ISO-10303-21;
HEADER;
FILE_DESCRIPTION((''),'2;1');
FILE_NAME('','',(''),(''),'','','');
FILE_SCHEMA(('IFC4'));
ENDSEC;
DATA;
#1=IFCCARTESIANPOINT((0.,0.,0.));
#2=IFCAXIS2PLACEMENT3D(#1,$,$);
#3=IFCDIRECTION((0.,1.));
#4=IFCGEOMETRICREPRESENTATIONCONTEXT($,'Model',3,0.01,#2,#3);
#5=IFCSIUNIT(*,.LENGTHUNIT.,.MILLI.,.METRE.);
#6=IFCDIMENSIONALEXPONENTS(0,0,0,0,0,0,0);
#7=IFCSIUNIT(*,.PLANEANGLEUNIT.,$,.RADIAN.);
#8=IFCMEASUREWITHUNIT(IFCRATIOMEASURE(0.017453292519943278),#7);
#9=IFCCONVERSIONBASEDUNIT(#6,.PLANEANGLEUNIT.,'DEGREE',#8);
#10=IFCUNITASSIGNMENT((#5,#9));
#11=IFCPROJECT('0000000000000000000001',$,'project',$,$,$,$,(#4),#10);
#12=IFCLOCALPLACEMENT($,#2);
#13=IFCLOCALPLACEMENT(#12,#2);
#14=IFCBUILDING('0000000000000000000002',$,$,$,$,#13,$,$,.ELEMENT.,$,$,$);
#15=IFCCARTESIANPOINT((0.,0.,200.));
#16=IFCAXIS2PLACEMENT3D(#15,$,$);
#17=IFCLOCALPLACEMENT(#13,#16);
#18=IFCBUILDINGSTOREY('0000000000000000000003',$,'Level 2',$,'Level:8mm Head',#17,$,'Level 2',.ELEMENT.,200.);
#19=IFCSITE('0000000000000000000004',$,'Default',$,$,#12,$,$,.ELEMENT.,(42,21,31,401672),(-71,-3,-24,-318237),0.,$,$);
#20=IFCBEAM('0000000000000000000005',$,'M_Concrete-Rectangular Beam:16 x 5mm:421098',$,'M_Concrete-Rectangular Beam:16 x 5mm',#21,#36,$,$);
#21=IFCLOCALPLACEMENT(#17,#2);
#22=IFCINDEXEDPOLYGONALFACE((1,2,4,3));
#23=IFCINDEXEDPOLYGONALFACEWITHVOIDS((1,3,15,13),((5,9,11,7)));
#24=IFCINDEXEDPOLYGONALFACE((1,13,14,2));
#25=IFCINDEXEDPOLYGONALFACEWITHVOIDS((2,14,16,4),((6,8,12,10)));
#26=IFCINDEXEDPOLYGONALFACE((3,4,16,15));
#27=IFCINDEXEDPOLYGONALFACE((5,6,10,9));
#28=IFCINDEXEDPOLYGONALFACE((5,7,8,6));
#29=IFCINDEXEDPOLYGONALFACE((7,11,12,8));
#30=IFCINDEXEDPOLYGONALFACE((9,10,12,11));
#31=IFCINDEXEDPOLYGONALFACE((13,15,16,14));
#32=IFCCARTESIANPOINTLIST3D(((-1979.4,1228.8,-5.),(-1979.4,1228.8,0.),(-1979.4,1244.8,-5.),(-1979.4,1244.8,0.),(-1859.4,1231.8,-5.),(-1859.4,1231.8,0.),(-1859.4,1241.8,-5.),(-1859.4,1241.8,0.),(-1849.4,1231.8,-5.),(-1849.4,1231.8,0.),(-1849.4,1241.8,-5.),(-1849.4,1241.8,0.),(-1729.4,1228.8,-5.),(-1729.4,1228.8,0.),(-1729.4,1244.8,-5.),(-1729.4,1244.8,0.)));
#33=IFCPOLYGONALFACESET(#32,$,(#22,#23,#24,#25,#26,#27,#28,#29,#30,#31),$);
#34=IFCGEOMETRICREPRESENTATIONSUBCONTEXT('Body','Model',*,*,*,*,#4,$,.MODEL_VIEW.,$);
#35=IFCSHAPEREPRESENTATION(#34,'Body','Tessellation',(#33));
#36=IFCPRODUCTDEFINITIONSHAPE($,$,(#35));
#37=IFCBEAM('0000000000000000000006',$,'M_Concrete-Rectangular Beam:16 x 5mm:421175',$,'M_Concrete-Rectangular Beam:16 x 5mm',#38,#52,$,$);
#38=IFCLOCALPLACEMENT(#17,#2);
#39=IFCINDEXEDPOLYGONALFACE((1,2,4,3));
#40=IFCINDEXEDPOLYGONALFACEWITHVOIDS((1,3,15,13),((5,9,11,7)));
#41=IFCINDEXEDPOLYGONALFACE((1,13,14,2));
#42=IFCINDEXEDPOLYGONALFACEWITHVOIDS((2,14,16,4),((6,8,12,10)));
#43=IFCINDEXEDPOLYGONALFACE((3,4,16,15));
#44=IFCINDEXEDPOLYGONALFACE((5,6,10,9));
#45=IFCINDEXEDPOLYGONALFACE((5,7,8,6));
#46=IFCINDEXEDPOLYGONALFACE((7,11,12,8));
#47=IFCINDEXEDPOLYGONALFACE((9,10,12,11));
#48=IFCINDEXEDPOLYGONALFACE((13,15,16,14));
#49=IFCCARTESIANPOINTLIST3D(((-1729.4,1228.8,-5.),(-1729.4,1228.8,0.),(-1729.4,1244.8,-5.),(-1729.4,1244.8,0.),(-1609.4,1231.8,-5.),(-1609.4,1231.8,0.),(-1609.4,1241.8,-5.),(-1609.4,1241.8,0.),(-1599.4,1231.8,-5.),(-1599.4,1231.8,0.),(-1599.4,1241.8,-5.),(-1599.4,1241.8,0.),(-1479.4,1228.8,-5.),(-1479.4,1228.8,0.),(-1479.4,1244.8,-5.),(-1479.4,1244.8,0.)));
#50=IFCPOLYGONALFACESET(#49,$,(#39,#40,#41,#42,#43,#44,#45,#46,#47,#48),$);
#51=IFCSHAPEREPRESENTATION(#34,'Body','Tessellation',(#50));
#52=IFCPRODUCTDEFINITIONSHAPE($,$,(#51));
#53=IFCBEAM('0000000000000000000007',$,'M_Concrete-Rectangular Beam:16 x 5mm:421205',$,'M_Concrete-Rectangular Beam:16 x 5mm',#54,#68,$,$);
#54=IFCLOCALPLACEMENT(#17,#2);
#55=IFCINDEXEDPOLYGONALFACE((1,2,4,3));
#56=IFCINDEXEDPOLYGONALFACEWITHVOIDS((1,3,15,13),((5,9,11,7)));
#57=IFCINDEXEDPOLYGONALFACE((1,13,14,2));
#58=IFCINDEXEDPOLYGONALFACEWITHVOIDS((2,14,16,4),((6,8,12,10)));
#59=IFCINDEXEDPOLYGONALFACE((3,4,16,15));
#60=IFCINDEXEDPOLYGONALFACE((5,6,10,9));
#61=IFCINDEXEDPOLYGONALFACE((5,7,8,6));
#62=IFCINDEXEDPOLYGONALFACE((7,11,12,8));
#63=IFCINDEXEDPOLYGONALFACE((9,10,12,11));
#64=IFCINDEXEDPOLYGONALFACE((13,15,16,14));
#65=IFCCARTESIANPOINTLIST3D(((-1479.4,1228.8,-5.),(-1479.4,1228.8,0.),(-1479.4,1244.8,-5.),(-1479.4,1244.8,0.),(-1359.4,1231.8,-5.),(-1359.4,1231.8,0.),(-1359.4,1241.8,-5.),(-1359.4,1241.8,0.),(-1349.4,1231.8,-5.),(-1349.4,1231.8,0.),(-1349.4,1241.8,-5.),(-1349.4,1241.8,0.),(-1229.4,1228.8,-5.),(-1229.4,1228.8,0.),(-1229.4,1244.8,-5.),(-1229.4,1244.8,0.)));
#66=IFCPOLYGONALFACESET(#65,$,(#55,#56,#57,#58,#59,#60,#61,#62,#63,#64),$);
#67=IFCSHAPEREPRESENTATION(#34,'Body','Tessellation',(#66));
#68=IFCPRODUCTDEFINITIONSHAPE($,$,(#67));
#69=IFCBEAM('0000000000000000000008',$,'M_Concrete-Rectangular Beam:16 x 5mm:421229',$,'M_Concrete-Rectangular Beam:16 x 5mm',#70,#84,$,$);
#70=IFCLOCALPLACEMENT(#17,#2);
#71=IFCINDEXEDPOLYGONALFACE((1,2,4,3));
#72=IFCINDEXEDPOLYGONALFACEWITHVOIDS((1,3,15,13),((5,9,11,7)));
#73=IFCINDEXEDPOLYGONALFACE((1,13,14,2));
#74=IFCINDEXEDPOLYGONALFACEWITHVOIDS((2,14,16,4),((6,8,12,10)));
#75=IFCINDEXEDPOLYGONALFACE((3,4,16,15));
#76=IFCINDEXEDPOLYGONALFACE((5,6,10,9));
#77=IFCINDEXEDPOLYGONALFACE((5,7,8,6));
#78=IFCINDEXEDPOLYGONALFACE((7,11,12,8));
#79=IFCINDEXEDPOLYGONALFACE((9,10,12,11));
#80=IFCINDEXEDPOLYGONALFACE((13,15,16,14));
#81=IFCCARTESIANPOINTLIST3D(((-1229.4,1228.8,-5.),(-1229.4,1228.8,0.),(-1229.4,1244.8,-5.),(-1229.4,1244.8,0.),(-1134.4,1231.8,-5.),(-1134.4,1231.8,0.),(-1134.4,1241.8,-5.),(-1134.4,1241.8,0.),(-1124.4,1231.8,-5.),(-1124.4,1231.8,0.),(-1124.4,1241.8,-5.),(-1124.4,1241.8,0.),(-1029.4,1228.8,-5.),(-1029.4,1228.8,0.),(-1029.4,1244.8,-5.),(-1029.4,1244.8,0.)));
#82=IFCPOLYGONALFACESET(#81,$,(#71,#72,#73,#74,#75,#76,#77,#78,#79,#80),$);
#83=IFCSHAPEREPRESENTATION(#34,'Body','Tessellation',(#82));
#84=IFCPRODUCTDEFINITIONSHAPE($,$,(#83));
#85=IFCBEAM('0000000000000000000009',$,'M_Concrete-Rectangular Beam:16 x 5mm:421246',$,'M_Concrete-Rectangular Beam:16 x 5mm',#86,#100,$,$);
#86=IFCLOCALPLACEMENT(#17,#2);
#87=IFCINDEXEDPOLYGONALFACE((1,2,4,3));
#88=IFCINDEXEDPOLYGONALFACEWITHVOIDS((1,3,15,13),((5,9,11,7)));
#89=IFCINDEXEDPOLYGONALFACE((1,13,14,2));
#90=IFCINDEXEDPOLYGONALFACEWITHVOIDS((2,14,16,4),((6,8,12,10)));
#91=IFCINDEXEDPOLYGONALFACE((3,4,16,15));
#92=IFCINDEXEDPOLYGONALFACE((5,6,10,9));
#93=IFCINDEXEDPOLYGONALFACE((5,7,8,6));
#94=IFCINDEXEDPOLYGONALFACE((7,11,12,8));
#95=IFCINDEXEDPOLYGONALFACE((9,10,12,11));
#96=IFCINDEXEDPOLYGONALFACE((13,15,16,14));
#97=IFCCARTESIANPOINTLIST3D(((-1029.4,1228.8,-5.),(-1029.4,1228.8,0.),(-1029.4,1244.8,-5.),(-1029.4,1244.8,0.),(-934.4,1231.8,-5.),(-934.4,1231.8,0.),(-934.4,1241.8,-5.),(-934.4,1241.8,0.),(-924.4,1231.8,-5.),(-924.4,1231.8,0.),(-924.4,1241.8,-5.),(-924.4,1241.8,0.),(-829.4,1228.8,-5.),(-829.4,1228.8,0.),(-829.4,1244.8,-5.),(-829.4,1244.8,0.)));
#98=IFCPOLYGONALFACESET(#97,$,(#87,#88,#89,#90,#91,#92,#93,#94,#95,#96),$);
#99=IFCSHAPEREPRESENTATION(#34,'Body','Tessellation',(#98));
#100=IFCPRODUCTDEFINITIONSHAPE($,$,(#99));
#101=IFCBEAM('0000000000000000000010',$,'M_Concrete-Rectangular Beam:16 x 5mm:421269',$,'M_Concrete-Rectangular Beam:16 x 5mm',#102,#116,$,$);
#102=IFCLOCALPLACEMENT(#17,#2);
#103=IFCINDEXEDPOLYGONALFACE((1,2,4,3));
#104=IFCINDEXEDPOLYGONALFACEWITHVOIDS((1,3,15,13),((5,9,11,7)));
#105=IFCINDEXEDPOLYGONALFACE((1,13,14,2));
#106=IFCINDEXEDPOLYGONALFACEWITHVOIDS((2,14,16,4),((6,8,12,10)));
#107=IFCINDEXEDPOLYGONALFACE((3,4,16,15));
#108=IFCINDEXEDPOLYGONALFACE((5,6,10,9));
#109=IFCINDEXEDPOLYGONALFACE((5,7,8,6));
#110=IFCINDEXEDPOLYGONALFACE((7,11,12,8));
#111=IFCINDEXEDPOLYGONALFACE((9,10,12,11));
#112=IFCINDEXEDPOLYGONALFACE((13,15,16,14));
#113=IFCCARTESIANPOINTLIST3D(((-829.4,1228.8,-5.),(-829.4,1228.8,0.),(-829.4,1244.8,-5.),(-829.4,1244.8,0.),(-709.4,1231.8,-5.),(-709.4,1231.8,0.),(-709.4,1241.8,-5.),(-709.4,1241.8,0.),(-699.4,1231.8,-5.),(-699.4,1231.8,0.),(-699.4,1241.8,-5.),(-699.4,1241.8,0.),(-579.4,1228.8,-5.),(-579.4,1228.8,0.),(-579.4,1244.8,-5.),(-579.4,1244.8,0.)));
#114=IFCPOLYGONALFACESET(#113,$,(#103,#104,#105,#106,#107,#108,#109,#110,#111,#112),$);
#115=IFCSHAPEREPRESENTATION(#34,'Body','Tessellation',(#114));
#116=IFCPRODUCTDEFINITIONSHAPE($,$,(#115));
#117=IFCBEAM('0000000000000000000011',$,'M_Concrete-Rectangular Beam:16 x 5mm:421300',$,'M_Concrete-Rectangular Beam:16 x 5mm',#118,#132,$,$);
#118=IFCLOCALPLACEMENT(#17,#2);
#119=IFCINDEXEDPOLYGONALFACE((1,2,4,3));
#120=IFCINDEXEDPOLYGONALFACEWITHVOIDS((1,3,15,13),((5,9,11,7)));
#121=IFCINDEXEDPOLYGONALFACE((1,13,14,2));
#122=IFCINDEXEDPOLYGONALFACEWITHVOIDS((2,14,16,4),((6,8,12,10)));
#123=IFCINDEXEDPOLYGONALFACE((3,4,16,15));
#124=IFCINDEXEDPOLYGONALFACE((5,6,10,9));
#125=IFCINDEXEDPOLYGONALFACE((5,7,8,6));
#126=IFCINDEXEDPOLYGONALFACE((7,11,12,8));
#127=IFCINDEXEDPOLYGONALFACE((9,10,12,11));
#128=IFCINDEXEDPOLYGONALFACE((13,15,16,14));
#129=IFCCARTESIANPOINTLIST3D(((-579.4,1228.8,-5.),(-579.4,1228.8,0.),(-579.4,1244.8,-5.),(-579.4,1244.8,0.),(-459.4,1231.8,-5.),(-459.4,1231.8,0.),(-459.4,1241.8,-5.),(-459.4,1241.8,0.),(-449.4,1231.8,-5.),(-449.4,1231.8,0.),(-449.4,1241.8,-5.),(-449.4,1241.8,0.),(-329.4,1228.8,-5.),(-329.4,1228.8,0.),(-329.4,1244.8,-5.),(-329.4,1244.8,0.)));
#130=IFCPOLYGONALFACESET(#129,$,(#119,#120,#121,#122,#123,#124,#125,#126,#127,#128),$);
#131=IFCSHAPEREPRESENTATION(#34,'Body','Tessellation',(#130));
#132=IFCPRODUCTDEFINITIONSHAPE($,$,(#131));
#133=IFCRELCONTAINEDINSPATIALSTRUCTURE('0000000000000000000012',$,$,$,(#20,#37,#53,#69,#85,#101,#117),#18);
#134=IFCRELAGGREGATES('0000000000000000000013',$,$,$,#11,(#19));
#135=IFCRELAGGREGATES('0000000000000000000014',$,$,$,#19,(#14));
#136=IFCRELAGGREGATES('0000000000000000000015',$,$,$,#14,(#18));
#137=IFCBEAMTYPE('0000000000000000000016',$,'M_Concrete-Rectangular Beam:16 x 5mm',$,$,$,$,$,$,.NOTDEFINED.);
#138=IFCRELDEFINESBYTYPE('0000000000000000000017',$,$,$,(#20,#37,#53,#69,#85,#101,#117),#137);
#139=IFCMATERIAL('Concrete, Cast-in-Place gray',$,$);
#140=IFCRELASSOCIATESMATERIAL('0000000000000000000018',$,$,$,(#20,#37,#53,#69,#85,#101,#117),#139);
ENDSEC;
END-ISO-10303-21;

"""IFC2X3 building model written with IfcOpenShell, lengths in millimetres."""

from ifc_helpers import new_model, entity, si_unit, converted_unit, direction, frame, frame_2d, origin, place, context, subcontext, project, spatial, rectangle, extrude, boolean, material, type_object, element, save


model = new_model("IFC2X3")

# Units and contexts
model_context = context("Model", 3, precision=0.01, world=origin(), true_north=direction((0.0, 1.0)))
body_context = subcontext(model_context, "Body", "Model", "MODEL_VIEW")
ifc_project = project(units=[si_unit("LENGTHUNIT", "METRE", prefix="MILLI"), converted_unit("PLANEANGLEUNIT", "DEGREE", entity("IfcRatioMeasure", 0.017453292519943278), si_unit("PLANEANGLEUNIT", "RADIAN"), dimensions=[0, 0, 0, 0, 0, 0, 0])], contexts=[model_context])

# Site, building, storey
site_placement = place(None, origin())
site = spatial("IfcSite", under=ifc_project, at=site_placement, Name="Default", CompositionType="ELEMENT", RefLatitude=(42, 21, 31, 401672), RefLongitude=(-71, -3, -24, -318237), RefElevation=0.0)
building_placement = place(site_placement, origin())
building = spatial("IfcBuilding", under=site, at=building_placement, CompositionType="ELEMENT")
storey_placement = place(building_placement, frame((0.0, 0.0, 200.0)))
storey = spatial("IfcBuildingStorey", under=building, at=storey_placement, Name="Level 2", ObjectType="Level:8mm Head", LongName="Level 2", CompositionType="ELEMENT", Elevation=200.0)

# Shared definitions
ifc_material = material(Name="Concrete, Cast-in-Place gray")

# Beams
beam_type = type_object("IfcBeamType", Name="M_Concrete-Rectangular Beam:16 x 5mm", PredefinedType="NOTDEFINED")
for number, where, name in (
    (1, (-1979.4, 1236.8, 0.0), "M_Concrete-Rectangular Beam:16 x 5mm:421098"),
    (2, (-1729.4, 1236.8, 0.0), "M_Concrete-Rectangular Beam:16 x 5mm:421175"),
    (3, (-1479.4, 1236.8, 0.0), "M_Concrete-Rectangular Beam:16 x 5mm:421205"),
):
    element("IfcBeam", number, at=place(storey_placement, frame(where)), inside=storey, type_object=beam_type, material=ifc_material, Name=name, ObjectType="M_Concrete-Rectangular Beam:16 x 5mm", context=body_context, shape_type="SweptSolid", body=[
        boolean("DIFFERENCE", extrude(rectangle(XDim=5.0, YDim=16.0, at=frame_2d((0.0, 0.0), x_axis=(1.0, 0.0))), frame((0.0, 0.0, -2.5), z_axis=(1.0, 0.0, 0.0), x_axis=(0.0, 0.0, -1.0)), (0.0, 0.0, 1.0), 250.0), extrude(rectangle(XDim=10.0, YDim=10.0, at=frame_2d((0.0, 0.0), x_axis=(1.0, 0.0))), frame((125.0, 0.0, 0.0), z_axis=(0.0, 0.0, -1.0), x_axis=(0.0, -1.0, 0.0)), (0.0, 0.0, 1.0), 5.0)),
    ])
beam_1_placement = place(storey_placement, frame((-1229.4, 1236.8, 0.0)))
element("IfcBeam", 4, at=beam_1_placement, inside=storey, type_object=beam_type, material=ifc_material, Name="M_Concrete-Rectangular Beam:16 x 5mm:421229", ObjectType="M_Concrete-Rectangular Beam:16 x 5mm", context=body_context, shape_type="SweptSolid", body=[
    boolean("DIFFERENCE", extrude(rectangle(XDim=5.0, YDim=16.0, at=frame_2d((0.0, 0.0), x_axis=(1.0, 0.0))), frame((0.0, 0.0, -2.5), z_axis=(1.0, 0.0, 0.0), x_axis=(0.0, 0.0, -1.0)), (0.0, 0.0, 1.0), 200.0), extrude(rectangle(XDim=10.0, YDim=10.0, at=frame_2d((0.0, 0.0), x_axis=(1.0, 0.0))), frame((100.0, 0.0, 0.0), z_axis=(0.0, 0.0, -1.0), x_axis=(0.0, -1.0, 0.0)), (0.0, 0.0, 1.0), 5.0)),
])
beam_2_placement = place(storey_placement, frame((-1029.4, 1236.8, 0.0)))
element("IfcBeam", 5, at=beam_2_placement, inside=storey, type_object=beam_type, material=ifc_material, Name="M_Concrete-Rectangular Beam:16 x 5mm:421246", ObjectType="M_Concrete-Rectangular Beam:16 x 5mm", context=body_context, shape_type="SweptSolid", body=[
    boolean("DIFFERENCE", extrude(rectangle(XDim=5.0, YDim=16.0, at=frame_2d((0.0, 0.0), x_axis=(1.0, 0.0))), frame((0.0, 0.0, -2.5), z_axis=(1.0, 0.0, 0.0), x_axis=(0.0, 0.0, -1.0)), (0.0, 0.0, 1.0), 200.0), extrude(rectangle(XDim=10.0, YDim=10.0, at=frame_2d((0.0, 0.0), x_axis=(1.0, 0.0))), frame((100.0, 0.0, 0.0), z_axis=(0.0, 0.0, -1.0), x_axis=(0.0, -1.0, 0.0)), (0.0, 0.0, 1.0), 5.0)),
])
beam_3_placement = place(storey_placement, frame((-829.4, 1236.8, 0.0)))
element("IfcBeam", 6, at=beam_3_placement, inside=storey, type_object=beam_type, material=ifc_material, Name="M_Concrete-Rectangular Beam:16 x 5mm:421269", ObjectType="M_Concrete-Rectangular Beam:16 x 5mm", context=body_context, shape_type="SweptSolid", body=[
    boolean("DIFFERENCE", extrude(rectangle(XDim=5.0, YDim=16.0, at=frame_2d((0.0, 0.0), x_axis=(1.0, 0.0))), frame((0.0, 0.0, -2.5), z_axis=(1.0, 0.0, 0.0), x_axis=(0.0, 0.0, -1.0)), (0.0, 0.0, 1.0), 250.0), extrude(rectangle(XDim=10.0, YDim=10.0, at=frame_2d((0.0, 0.0), x_axis=(1.0, 0.0))), frame((125.0, 0.0, 0.0), z_axis=(0.0, 0.0, -1.0), x_axis=(0.0, -1.0, 0.0)), (0.0, 0.0, 1.0), 5.0)),
])
beam_4_placement = place(storey_placement, frame((-579.4, 1236.8, 0.0)))
element("IfcBeam", 7, at=beam_4_placement, inside=storey, type_object=beam_type, material=ifc_material, Name="M_Concrete-Rectangular Beam:16 x 5mm:421300", ObjectType="M_Concrete-Rectangular Beam:16 x 5mm", context=body_context, shape_type="SweptSolid", body=[
    boolean("DIFFERENCE", extrude(rectangle(XDim=5.0, YDim=16.0, at=frame_2d((0.0, 0.0), x_axis=(1.0, 0.0))), frame((0.0, 0.0, -2.5), z_axis=(1.0, 0.0, 0.0), x_axis=(0.0, 0.0, -1.0)), (0.0, 0.0, 1.0), 250.0), extrude(rectangle(XDim=10.0, YDim=10.0, at=frame_2d((0.0, 0.0), x_axis=(1.0, 0.0))), frame((125.0, 0.0, 0.0), z_axis=(0.0, 0.0, -1.0), x_axis=(0.0, -1.0, 0.0)), (0.0, 0.0, 1.0), 5.0)),
])

save(model, "model.ifc")
